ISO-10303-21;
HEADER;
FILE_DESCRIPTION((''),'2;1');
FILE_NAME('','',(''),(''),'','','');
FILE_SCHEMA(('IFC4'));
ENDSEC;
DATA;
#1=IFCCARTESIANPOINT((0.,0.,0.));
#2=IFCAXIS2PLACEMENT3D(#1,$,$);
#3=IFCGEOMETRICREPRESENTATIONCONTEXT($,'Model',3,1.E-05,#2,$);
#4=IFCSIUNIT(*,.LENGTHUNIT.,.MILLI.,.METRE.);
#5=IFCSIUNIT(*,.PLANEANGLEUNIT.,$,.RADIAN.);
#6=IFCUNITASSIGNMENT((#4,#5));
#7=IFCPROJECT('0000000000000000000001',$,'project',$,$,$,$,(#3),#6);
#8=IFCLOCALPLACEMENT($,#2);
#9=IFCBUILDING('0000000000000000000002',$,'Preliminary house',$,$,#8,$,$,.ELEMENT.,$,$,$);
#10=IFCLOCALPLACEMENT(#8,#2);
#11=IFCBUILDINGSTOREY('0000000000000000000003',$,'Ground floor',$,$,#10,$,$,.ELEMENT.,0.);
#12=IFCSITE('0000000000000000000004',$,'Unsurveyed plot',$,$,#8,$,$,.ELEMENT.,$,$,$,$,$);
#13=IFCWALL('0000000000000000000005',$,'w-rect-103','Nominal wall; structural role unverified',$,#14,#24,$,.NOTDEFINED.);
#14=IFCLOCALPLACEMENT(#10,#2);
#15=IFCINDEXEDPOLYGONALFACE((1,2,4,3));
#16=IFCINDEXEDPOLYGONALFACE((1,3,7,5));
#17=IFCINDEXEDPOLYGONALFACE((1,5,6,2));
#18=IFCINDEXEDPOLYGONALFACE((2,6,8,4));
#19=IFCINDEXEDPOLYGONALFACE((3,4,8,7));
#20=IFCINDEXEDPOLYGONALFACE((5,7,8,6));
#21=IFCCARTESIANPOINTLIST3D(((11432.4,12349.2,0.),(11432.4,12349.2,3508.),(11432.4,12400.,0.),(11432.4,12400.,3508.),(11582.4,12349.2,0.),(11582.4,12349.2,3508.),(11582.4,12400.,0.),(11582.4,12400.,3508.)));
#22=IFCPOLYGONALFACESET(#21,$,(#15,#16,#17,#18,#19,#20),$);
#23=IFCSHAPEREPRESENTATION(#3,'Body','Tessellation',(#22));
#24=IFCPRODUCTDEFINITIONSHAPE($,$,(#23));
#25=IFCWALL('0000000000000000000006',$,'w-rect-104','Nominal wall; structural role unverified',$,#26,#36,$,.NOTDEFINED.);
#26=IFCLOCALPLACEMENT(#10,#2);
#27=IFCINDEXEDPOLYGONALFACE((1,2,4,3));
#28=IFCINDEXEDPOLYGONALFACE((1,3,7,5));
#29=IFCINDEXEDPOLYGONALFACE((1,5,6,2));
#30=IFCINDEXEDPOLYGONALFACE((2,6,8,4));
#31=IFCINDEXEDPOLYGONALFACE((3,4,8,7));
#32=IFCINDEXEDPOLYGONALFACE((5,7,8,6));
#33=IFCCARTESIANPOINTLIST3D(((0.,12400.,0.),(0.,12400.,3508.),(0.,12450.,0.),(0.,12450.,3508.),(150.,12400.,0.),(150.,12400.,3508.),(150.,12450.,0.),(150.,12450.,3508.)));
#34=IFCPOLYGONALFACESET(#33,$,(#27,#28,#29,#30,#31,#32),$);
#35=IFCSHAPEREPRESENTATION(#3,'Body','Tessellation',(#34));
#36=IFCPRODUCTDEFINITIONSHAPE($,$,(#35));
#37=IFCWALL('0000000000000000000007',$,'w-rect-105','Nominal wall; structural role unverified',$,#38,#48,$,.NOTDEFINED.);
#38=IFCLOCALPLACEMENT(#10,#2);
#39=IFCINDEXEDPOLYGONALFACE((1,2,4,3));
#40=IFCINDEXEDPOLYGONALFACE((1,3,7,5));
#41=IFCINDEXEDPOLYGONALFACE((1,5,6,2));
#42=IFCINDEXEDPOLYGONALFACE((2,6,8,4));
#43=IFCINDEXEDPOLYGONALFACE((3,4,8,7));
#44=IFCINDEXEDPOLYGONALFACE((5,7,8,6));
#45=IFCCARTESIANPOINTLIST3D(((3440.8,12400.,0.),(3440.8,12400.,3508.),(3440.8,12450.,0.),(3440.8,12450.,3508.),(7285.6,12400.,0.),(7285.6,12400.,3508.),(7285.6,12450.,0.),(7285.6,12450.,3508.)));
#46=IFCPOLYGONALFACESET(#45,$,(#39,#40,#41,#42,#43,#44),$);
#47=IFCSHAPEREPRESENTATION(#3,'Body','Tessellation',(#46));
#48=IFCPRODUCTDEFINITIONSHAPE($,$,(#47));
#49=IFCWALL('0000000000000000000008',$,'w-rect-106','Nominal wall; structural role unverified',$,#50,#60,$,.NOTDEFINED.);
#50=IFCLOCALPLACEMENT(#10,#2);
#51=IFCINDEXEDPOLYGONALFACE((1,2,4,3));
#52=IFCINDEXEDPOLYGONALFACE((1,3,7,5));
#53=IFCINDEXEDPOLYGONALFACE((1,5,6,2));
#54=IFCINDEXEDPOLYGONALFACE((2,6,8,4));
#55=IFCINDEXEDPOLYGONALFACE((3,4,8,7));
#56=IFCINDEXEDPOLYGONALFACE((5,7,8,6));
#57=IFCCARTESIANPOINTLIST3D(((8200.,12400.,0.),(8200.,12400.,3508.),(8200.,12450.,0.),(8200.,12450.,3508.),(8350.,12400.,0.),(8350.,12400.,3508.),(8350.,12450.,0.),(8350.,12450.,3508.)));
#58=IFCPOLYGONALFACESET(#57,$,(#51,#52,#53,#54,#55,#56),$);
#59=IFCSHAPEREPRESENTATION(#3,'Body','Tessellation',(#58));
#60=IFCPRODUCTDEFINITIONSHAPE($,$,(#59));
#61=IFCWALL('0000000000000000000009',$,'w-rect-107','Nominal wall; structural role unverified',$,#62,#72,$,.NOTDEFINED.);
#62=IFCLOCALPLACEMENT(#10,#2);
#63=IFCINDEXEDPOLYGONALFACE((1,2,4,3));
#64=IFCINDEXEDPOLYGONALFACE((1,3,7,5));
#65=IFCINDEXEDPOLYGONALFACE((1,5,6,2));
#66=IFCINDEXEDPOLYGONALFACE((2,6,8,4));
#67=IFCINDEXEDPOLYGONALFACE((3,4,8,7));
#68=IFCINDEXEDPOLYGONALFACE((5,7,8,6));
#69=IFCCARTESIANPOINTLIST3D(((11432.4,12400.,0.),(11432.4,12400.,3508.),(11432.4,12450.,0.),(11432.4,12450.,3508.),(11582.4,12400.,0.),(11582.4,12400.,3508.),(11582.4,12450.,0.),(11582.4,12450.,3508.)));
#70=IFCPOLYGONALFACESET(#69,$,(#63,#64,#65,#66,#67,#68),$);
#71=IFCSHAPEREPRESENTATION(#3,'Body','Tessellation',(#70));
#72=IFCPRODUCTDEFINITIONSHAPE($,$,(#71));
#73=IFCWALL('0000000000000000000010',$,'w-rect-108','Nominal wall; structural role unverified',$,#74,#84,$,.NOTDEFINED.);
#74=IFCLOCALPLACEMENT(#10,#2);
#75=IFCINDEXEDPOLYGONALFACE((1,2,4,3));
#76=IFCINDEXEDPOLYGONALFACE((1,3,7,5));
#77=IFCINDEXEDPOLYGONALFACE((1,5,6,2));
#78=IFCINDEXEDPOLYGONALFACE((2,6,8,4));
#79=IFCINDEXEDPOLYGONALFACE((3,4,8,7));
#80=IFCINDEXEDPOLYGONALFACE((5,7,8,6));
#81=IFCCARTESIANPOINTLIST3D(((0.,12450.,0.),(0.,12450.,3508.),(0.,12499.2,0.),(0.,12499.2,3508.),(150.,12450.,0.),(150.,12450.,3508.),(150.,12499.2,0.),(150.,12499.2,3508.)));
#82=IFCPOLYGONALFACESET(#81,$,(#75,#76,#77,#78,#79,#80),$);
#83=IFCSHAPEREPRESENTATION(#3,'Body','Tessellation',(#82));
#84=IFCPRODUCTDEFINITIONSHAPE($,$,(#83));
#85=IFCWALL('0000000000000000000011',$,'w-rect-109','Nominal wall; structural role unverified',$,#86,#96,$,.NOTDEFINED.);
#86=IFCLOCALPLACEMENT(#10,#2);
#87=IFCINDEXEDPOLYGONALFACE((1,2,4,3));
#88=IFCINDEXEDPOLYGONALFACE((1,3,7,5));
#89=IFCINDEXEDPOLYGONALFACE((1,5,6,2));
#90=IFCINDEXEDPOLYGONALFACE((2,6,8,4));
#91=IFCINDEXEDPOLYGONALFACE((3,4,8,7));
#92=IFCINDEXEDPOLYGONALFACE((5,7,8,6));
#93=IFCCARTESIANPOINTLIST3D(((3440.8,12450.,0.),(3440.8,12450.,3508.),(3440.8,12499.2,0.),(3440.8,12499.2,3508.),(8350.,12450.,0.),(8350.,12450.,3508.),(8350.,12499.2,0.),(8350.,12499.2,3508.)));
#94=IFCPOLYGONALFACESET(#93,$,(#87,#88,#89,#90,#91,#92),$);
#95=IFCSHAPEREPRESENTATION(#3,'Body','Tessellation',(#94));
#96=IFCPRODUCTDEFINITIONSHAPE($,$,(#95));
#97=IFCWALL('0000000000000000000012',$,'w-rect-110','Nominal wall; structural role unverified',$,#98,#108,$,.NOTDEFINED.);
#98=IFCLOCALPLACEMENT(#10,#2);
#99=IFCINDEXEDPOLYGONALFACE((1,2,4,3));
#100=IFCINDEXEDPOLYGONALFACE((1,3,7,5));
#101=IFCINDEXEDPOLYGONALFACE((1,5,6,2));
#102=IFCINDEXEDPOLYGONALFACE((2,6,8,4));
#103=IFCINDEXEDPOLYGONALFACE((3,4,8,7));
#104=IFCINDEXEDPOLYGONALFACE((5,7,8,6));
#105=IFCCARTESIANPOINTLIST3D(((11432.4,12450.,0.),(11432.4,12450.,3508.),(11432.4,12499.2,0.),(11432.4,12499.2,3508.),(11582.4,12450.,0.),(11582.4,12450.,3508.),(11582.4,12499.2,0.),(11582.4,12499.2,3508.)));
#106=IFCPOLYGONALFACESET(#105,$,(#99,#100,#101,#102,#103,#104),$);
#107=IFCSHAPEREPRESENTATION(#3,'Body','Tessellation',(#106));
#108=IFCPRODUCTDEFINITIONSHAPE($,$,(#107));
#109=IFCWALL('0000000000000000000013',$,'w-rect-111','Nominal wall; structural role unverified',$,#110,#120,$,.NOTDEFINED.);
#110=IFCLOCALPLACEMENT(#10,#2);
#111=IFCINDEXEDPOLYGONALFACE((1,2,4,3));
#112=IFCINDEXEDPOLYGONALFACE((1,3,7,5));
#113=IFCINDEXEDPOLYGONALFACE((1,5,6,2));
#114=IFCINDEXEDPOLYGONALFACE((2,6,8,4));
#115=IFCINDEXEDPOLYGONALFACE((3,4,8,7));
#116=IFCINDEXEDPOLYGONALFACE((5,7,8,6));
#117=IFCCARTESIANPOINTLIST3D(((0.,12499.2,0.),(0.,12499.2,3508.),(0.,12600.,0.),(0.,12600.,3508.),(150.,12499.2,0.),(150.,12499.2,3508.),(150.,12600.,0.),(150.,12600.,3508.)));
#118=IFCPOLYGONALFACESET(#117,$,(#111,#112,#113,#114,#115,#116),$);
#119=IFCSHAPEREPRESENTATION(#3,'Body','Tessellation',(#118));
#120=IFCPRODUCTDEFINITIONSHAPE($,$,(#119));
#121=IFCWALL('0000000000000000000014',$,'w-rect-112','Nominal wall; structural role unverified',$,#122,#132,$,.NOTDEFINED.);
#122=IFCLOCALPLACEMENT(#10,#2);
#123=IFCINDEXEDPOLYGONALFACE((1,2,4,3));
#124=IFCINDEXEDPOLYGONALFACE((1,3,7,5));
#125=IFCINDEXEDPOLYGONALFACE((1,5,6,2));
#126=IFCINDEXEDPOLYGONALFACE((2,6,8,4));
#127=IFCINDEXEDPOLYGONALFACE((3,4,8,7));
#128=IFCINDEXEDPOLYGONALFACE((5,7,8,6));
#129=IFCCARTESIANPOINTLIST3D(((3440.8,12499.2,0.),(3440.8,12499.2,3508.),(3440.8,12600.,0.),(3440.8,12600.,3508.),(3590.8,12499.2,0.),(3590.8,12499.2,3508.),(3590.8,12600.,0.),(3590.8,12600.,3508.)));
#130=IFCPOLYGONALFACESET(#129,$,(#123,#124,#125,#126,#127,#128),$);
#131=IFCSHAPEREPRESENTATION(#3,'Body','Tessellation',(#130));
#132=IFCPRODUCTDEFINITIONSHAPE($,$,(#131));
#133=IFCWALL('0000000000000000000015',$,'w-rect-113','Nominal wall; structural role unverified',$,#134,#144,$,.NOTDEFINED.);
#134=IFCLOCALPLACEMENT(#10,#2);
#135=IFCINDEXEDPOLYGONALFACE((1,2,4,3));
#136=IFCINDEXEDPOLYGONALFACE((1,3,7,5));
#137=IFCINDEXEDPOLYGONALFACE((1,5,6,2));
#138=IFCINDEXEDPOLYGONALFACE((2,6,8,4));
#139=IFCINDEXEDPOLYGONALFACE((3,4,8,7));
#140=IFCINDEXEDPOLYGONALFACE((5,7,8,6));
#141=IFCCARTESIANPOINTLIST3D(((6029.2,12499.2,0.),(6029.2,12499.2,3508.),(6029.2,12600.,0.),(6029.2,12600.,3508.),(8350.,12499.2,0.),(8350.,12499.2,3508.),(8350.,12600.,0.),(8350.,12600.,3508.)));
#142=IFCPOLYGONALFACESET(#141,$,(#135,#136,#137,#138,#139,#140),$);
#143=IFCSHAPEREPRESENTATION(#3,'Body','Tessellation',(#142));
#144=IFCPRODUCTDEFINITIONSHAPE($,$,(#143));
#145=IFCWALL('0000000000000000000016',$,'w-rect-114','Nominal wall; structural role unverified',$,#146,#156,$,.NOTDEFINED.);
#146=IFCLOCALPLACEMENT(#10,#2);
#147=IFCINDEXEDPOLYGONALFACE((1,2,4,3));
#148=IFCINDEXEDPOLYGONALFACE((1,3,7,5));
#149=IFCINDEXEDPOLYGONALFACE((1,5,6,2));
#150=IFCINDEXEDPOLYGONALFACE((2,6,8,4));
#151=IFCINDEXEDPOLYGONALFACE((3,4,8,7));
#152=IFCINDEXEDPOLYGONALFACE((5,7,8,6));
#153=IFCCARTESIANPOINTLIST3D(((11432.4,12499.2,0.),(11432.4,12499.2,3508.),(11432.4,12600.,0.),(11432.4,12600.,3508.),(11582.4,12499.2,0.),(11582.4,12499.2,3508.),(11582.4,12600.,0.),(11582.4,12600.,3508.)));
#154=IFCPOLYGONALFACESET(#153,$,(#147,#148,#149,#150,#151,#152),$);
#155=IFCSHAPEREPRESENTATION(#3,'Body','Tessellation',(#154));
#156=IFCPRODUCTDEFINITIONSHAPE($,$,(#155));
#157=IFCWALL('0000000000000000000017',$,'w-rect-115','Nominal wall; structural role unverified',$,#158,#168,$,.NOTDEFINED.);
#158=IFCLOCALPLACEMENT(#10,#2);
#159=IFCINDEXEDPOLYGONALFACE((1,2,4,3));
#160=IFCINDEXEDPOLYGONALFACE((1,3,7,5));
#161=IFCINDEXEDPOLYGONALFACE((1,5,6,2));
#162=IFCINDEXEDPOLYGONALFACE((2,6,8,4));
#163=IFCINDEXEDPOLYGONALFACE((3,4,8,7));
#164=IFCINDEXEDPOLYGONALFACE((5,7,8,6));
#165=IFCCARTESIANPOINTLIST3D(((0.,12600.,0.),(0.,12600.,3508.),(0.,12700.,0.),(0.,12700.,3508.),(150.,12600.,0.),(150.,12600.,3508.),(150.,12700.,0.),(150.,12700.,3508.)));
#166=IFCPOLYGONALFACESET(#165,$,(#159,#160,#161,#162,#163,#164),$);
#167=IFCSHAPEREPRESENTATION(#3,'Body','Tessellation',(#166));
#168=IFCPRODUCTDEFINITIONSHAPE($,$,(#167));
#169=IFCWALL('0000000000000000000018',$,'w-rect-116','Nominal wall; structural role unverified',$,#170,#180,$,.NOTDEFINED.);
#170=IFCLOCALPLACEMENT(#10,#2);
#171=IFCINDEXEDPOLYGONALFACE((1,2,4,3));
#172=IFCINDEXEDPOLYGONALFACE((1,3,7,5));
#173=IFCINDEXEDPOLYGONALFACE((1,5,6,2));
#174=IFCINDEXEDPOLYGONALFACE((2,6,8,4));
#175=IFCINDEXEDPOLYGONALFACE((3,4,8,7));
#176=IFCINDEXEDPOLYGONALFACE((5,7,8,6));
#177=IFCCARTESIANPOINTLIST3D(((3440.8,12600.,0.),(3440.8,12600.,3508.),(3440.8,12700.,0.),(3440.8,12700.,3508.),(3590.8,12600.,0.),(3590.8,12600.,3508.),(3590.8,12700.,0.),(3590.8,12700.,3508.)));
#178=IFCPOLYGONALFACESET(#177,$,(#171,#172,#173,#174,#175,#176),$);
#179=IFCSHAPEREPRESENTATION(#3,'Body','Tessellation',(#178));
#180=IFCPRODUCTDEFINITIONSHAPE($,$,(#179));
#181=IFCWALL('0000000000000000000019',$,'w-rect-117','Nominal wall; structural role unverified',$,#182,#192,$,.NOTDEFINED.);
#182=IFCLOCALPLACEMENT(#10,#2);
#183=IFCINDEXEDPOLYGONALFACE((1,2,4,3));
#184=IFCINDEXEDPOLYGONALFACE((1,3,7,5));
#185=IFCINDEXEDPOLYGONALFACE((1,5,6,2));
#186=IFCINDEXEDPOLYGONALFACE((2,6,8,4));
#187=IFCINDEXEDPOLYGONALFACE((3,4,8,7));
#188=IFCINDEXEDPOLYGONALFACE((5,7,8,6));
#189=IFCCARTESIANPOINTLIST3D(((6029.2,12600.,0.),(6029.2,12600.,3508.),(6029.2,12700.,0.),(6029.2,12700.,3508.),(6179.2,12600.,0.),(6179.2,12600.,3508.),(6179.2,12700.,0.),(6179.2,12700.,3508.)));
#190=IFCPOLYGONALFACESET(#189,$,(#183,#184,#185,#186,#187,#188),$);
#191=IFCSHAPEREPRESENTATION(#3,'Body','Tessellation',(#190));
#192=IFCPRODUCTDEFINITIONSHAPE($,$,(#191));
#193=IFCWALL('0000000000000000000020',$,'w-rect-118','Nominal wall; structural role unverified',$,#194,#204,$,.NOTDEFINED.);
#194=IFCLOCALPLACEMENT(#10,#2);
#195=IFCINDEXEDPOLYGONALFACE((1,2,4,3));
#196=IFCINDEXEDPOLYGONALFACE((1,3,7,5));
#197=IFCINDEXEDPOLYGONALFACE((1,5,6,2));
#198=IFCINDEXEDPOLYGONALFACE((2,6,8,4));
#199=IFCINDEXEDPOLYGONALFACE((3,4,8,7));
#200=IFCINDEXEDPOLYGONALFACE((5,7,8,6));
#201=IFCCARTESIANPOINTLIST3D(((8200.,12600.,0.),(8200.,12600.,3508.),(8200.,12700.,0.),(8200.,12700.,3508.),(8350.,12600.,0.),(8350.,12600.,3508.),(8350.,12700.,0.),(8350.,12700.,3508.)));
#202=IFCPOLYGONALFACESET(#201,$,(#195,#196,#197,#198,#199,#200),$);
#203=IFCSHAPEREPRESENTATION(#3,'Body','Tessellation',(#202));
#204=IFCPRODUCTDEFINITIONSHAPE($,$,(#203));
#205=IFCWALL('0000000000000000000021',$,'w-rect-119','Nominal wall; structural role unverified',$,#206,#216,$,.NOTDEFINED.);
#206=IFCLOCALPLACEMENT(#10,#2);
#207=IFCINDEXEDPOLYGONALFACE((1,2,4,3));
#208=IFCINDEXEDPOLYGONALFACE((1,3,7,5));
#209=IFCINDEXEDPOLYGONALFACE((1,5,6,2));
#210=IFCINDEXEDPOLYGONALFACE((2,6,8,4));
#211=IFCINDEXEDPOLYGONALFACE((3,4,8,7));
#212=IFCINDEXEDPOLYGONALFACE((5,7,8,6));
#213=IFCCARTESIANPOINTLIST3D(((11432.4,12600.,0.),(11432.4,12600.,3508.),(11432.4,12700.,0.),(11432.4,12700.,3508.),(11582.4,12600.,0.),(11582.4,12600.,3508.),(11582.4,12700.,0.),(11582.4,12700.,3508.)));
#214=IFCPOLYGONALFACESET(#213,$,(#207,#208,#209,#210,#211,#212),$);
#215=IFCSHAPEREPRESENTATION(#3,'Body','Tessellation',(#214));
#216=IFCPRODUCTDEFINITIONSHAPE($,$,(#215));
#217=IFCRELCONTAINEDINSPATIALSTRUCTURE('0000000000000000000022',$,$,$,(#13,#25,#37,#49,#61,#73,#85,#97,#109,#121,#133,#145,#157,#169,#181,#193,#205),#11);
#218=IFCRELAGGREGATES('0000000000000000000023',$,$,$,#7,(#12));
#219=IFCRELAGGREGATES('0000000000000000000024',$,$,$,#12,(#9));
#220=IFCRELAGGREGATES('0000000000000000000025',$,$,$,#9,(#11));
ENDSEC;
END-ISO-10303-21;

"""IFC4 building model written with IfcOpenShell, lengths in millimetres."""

from ifc_helpers import new_model, si_unit, origin, place, context, project, spatial, polyline, outline, extrude, element, save


model = new_model("IFC4")

# Units and contexts
model_context = context("Model", 3, precision=1e-05, world=origin())
ifc_project = project(units=[si_unit("LENGTHUNIT", "METRE", prefix="MILLI"), si_unit("PLANEANGLEUNIT", "RADIAN")], contexts=[model_context])

# Site, building, storey
placement_1 = place(None, origin())
site = spatial("IfcSite", under=ifc_project, at=placement_1, Name="Unsurveyed plot", CompositionType="ELEMENT")
building = spatial("IfcBuilding", under=site, at=placement_1, Name="Preliminary house", CompositionType="ELEMENT")
placement_2 = place(placement_1, origin())
storey = spatial("IfcBuildingStorey", under=building, at=placement_2, Name="Ground floor", CompositionType="ELEMENT", Elevation=0.0)

# Walls
element("IfcWall", 1, at=placement_2, inside=storey, Name="w-rect-103", Description="Nominal wall; structural role unverified", PredefinedType="NOTDEFINED", context=model_context, shape_type="SweptSolid", body=[
    extrude(outline(polyline([(11432.4, 12349.2), (11582.4, 12349.2), (11582.4, 12400.0), (11432.4, 12400.0), (11432.4, 12349.2)])), origin(), (0.0, 0.0, 1.0), 3508.0),
])
element("IfcWall", 2, at=placement_2, inside=storey, Name="w-rect-104", Description="Nominal wall; structural role unverified", PredefinedType="NOTDEFINED", context=model_context, shape_type="SweptSolid", body=[
    extrude(outline(polyline([(0.0, 12400.0), (150.0, 12400.0), (150.0, 12450.0), (0.0, 12450.0), (0.0, 12400.0)])), origin(), (0.0, 0.0, 1.0), 3508.0),
])
element("IfcWall", 3, at=placement_2, inside=storey, Name="w-rect-105", Description="Nominal wall; structural role unverified", PredefinedType="NOTDEFINED", context=model_context, shape_type="SweptSolid", body=[
    extrude(outline(polyline([(3440.8, 12400.0), (7285.6, 12400.0), (7285.6, 12450.0), (3440.8, 12450.0), (3440.8, 12400.0)])), origin(), (0.0, 0.0, 1.0), 3508.0),
])
element("IfcWall", 4, at=placement_2, inside=storey, Name="w-rect-106", Description="Nominal wall; structural role unverified", PredefinedType="NOTDEFINED", context=model_context, shape_type="SweptSolid", body=[
    extrude(outline(polyline([(8200.0, 12400.0), (8350.0, 12400.0), (8350.0, 12450.0), (8200.0, 12450.0), (8200.0, 12400.0)])), origin(), (0.0, 0.0, 1.0), 3508.0),
])
element("IfcWall", 5, at=placement_2, inside=storey, Name="w-rect-107", Description="Nominal wall; structural role unverified", PredefinedType="NOTDEFINED", context=model_context, shape_type="SweptSolid", body=[
    extrude(outline(polyline([(11432.4, 12400.0), (11582.4, 12400.0), (11582.4, 12450.0), (11432.4, 12450.0), (11432.4, 12400.0)])), origin(), (0.0, 0.0, 1.0), 3508.0),
])
element("IfcWall", 6, at=placement_2, inside=storey, Name="w-rect-108", Description="Nominal wall; structural role unverified", PredefinedType="NOTDEFINED", context=model_context, shape_type="SweptSolid", body=[
    extrude(outline(polyline([(0.0, 12450.0), (150.0, 12450.0), (150.0, 12499.2), (0.0, 12499.2), (0.0, 12450.0)])), origin(), (0.0, 0.0, 1.0), 3508.0),
])
element("IfcWall", 7, at=placement_2, inside=storey, Name="w-rect-109", Description="Nominal wall; structural role unverified", PredefinedType="NOTDEFINED", context=model_context, shape_type="SweptSolid", body=[
    extrude(outline(polyline([(3440.8, 12450.0), (8350.0, 12450.0), (8350.0, 12499.2), (3440.8, 12499.2), (3440.8, 12450.0)])), origin(), (0.0, 0.0, 1.0), 3508.0),
])
element("IfcWall", 8, at=placement_2, inside=storey, Name="w-rect-110", Description="Nominal wall; structural role unverified", PredefinedType="NOTDEFINED", context=model_context, shape_type="SweptSolid", body=[
    extrude(outline(polyline([(11432.4, 12450.0), (11582.4, 12450.0), (11582.4, 12499.2), (11432.4, 12499.2), (11432.4, 12450.0)])), origin(), (0.0, 0.0, 1.0), 3508.0),
])
element("IfcWall", 9, at=placement_2, inside=storey, Name="w-rect-111", Description="Nominal wall; structural role unverified", PredefinedType="NOTDEFINED", context=model_context, shape_type="SweptSolid", body=[
    extrude(outline(polyline([(0.0, 12499.2), (150.0, 12499.2), (150.0, 12600.0), (0.0, 12600.0), (0.0, 12499.2)])), origin(), (0.0, 0.0, 1.0), 3508.0),
])
element("IfcWall", 10, at=placement_2, inside=storey, Name="w-rect-112", Description="Nominal wall; structural role unverified", PredefinedType="NOTDEFINED", context=model_context, shape_type="SweptSolid", body=[
    extrude(outline(polyline([(3440.8, 12499.2), (3590.8, 12499.2), (3590.8, 12600.0), (3440.8, 12600.0), (3440.8, 12499.2)])), origin(), (0.0, 0.0, 1.0), 3508.0),
])
element("IfcWall", 11, at=placement_2, inside=storey, Name="w-rect-113", Description="Nominal wall; structural role unverified", PredefinedType="NOTDEFINED", context=model_context, shape_type="SweptSolid", body=[
    extrude(outline(polyline([(6029.2, 12499.2), (8350.0, 12499.2), (8350.0, 12600.0), (6029.2, 12600.0), (6029.2, 12499.2)])), origin(), (0.0, 0.0, 1.0), 3508.0),
])
element("IfcWall", 12, at=placement_2, inside=storey, Name="w-rect-114", Description="Nominal wall; structural role unverified", PredefinedType="NOTDEFINED", context=model_context, shape_type="SweptSolid", body=[
    extrude(outline(polyline([(11432.4, 12499.2), (11582.4, 12499.2), (11582.4, 12600.0), (11432.4, 12600.0), (11432.4, 12499.2)])), origin(), (0.0, 0.0, 1.0), 3508.0),
])
element("IfcWall", 13, at=placement_2, inside=storey, Name="w-rect-115", Description="Nominal wall; structural role unverified", PredefinedType="NOTDEFINED", context=model_context, shape_type="SweptSolid", body=[
    extrude(outline(polyline([(0.0, 12600.0), (150.0, 12600.0), (150.0, 12700.0), (0.0, 12700.0), (0.0, 12600.0)])), origin(), (0.0, 0.0, 1.0), 3508.0),
])
element("IfcWall", 14, at=placement_2, inside=storey, Name="w-rect-116", Description="Nominal wall; structural role unverified", PredefinedType="NOTDEFINED", context=model_context, shape_type="SweptSolid", body=[
    extrude(outline(polyline([(3440.8, 12600.0), (3590.8, 12600.0), (3590.8, 12700.0), (3440.8, 12700.0), (3440.8, 12600.0)])), origin(), (0.0, 0.0, 1.0), 3508.0),
])
element("IfcWall", 15, at=placement_2, inside=storey, Name="w-rect-117", Description="Nominal wall; structural role unverified", PredefinedType="NOTDEFINED", context=model_context, shape_type="SweptSolid", body=[
    extrude(outline(polyline([(6029.2, 12600.0), (6179.2, 12600.0), (6179.2, 12700.0), (6029.2, 12700.0), (6029.2, 12600.0)])), origin(), (0.0, 0.0, 1.0), 3508.0),
])
element("IfcWall", 16, at=placement_2, inside=storey, Name="w-rect-118", Description="Nominal wall; structural role unverified", PredefinedType="NOTDEFINED", context=model_context, shape_type="SweptSolid", body=[
    extrude(outline(polyline([(8200.0, 12600.0), (8350.0, 12600.0), (8350.0, 12700.0), (8200.0, 12700.0), (8200.0, 12600.0)])), origin(), (0.0, 0.0, 1.0), 3508.0),
])
element("IfcWall", 17, at=placement_2, inside=storey, Name="w-rect-119", Description="Nominal wall; structural role unverified", PredefinedType="NOTDEFINED", context=model_context, shape_type="SweptSolid", body=[
    extrude(outline(polyline([(11432.4, 12600.0), (11582.4, 12600.0), (11582.4, 12700.0), (11432.4, 12700.0), (11432.4, 12600.0)])), origin(), (0.0, 0.0, 1.0), 3508.0),
])

save(model, "model.ifc")
